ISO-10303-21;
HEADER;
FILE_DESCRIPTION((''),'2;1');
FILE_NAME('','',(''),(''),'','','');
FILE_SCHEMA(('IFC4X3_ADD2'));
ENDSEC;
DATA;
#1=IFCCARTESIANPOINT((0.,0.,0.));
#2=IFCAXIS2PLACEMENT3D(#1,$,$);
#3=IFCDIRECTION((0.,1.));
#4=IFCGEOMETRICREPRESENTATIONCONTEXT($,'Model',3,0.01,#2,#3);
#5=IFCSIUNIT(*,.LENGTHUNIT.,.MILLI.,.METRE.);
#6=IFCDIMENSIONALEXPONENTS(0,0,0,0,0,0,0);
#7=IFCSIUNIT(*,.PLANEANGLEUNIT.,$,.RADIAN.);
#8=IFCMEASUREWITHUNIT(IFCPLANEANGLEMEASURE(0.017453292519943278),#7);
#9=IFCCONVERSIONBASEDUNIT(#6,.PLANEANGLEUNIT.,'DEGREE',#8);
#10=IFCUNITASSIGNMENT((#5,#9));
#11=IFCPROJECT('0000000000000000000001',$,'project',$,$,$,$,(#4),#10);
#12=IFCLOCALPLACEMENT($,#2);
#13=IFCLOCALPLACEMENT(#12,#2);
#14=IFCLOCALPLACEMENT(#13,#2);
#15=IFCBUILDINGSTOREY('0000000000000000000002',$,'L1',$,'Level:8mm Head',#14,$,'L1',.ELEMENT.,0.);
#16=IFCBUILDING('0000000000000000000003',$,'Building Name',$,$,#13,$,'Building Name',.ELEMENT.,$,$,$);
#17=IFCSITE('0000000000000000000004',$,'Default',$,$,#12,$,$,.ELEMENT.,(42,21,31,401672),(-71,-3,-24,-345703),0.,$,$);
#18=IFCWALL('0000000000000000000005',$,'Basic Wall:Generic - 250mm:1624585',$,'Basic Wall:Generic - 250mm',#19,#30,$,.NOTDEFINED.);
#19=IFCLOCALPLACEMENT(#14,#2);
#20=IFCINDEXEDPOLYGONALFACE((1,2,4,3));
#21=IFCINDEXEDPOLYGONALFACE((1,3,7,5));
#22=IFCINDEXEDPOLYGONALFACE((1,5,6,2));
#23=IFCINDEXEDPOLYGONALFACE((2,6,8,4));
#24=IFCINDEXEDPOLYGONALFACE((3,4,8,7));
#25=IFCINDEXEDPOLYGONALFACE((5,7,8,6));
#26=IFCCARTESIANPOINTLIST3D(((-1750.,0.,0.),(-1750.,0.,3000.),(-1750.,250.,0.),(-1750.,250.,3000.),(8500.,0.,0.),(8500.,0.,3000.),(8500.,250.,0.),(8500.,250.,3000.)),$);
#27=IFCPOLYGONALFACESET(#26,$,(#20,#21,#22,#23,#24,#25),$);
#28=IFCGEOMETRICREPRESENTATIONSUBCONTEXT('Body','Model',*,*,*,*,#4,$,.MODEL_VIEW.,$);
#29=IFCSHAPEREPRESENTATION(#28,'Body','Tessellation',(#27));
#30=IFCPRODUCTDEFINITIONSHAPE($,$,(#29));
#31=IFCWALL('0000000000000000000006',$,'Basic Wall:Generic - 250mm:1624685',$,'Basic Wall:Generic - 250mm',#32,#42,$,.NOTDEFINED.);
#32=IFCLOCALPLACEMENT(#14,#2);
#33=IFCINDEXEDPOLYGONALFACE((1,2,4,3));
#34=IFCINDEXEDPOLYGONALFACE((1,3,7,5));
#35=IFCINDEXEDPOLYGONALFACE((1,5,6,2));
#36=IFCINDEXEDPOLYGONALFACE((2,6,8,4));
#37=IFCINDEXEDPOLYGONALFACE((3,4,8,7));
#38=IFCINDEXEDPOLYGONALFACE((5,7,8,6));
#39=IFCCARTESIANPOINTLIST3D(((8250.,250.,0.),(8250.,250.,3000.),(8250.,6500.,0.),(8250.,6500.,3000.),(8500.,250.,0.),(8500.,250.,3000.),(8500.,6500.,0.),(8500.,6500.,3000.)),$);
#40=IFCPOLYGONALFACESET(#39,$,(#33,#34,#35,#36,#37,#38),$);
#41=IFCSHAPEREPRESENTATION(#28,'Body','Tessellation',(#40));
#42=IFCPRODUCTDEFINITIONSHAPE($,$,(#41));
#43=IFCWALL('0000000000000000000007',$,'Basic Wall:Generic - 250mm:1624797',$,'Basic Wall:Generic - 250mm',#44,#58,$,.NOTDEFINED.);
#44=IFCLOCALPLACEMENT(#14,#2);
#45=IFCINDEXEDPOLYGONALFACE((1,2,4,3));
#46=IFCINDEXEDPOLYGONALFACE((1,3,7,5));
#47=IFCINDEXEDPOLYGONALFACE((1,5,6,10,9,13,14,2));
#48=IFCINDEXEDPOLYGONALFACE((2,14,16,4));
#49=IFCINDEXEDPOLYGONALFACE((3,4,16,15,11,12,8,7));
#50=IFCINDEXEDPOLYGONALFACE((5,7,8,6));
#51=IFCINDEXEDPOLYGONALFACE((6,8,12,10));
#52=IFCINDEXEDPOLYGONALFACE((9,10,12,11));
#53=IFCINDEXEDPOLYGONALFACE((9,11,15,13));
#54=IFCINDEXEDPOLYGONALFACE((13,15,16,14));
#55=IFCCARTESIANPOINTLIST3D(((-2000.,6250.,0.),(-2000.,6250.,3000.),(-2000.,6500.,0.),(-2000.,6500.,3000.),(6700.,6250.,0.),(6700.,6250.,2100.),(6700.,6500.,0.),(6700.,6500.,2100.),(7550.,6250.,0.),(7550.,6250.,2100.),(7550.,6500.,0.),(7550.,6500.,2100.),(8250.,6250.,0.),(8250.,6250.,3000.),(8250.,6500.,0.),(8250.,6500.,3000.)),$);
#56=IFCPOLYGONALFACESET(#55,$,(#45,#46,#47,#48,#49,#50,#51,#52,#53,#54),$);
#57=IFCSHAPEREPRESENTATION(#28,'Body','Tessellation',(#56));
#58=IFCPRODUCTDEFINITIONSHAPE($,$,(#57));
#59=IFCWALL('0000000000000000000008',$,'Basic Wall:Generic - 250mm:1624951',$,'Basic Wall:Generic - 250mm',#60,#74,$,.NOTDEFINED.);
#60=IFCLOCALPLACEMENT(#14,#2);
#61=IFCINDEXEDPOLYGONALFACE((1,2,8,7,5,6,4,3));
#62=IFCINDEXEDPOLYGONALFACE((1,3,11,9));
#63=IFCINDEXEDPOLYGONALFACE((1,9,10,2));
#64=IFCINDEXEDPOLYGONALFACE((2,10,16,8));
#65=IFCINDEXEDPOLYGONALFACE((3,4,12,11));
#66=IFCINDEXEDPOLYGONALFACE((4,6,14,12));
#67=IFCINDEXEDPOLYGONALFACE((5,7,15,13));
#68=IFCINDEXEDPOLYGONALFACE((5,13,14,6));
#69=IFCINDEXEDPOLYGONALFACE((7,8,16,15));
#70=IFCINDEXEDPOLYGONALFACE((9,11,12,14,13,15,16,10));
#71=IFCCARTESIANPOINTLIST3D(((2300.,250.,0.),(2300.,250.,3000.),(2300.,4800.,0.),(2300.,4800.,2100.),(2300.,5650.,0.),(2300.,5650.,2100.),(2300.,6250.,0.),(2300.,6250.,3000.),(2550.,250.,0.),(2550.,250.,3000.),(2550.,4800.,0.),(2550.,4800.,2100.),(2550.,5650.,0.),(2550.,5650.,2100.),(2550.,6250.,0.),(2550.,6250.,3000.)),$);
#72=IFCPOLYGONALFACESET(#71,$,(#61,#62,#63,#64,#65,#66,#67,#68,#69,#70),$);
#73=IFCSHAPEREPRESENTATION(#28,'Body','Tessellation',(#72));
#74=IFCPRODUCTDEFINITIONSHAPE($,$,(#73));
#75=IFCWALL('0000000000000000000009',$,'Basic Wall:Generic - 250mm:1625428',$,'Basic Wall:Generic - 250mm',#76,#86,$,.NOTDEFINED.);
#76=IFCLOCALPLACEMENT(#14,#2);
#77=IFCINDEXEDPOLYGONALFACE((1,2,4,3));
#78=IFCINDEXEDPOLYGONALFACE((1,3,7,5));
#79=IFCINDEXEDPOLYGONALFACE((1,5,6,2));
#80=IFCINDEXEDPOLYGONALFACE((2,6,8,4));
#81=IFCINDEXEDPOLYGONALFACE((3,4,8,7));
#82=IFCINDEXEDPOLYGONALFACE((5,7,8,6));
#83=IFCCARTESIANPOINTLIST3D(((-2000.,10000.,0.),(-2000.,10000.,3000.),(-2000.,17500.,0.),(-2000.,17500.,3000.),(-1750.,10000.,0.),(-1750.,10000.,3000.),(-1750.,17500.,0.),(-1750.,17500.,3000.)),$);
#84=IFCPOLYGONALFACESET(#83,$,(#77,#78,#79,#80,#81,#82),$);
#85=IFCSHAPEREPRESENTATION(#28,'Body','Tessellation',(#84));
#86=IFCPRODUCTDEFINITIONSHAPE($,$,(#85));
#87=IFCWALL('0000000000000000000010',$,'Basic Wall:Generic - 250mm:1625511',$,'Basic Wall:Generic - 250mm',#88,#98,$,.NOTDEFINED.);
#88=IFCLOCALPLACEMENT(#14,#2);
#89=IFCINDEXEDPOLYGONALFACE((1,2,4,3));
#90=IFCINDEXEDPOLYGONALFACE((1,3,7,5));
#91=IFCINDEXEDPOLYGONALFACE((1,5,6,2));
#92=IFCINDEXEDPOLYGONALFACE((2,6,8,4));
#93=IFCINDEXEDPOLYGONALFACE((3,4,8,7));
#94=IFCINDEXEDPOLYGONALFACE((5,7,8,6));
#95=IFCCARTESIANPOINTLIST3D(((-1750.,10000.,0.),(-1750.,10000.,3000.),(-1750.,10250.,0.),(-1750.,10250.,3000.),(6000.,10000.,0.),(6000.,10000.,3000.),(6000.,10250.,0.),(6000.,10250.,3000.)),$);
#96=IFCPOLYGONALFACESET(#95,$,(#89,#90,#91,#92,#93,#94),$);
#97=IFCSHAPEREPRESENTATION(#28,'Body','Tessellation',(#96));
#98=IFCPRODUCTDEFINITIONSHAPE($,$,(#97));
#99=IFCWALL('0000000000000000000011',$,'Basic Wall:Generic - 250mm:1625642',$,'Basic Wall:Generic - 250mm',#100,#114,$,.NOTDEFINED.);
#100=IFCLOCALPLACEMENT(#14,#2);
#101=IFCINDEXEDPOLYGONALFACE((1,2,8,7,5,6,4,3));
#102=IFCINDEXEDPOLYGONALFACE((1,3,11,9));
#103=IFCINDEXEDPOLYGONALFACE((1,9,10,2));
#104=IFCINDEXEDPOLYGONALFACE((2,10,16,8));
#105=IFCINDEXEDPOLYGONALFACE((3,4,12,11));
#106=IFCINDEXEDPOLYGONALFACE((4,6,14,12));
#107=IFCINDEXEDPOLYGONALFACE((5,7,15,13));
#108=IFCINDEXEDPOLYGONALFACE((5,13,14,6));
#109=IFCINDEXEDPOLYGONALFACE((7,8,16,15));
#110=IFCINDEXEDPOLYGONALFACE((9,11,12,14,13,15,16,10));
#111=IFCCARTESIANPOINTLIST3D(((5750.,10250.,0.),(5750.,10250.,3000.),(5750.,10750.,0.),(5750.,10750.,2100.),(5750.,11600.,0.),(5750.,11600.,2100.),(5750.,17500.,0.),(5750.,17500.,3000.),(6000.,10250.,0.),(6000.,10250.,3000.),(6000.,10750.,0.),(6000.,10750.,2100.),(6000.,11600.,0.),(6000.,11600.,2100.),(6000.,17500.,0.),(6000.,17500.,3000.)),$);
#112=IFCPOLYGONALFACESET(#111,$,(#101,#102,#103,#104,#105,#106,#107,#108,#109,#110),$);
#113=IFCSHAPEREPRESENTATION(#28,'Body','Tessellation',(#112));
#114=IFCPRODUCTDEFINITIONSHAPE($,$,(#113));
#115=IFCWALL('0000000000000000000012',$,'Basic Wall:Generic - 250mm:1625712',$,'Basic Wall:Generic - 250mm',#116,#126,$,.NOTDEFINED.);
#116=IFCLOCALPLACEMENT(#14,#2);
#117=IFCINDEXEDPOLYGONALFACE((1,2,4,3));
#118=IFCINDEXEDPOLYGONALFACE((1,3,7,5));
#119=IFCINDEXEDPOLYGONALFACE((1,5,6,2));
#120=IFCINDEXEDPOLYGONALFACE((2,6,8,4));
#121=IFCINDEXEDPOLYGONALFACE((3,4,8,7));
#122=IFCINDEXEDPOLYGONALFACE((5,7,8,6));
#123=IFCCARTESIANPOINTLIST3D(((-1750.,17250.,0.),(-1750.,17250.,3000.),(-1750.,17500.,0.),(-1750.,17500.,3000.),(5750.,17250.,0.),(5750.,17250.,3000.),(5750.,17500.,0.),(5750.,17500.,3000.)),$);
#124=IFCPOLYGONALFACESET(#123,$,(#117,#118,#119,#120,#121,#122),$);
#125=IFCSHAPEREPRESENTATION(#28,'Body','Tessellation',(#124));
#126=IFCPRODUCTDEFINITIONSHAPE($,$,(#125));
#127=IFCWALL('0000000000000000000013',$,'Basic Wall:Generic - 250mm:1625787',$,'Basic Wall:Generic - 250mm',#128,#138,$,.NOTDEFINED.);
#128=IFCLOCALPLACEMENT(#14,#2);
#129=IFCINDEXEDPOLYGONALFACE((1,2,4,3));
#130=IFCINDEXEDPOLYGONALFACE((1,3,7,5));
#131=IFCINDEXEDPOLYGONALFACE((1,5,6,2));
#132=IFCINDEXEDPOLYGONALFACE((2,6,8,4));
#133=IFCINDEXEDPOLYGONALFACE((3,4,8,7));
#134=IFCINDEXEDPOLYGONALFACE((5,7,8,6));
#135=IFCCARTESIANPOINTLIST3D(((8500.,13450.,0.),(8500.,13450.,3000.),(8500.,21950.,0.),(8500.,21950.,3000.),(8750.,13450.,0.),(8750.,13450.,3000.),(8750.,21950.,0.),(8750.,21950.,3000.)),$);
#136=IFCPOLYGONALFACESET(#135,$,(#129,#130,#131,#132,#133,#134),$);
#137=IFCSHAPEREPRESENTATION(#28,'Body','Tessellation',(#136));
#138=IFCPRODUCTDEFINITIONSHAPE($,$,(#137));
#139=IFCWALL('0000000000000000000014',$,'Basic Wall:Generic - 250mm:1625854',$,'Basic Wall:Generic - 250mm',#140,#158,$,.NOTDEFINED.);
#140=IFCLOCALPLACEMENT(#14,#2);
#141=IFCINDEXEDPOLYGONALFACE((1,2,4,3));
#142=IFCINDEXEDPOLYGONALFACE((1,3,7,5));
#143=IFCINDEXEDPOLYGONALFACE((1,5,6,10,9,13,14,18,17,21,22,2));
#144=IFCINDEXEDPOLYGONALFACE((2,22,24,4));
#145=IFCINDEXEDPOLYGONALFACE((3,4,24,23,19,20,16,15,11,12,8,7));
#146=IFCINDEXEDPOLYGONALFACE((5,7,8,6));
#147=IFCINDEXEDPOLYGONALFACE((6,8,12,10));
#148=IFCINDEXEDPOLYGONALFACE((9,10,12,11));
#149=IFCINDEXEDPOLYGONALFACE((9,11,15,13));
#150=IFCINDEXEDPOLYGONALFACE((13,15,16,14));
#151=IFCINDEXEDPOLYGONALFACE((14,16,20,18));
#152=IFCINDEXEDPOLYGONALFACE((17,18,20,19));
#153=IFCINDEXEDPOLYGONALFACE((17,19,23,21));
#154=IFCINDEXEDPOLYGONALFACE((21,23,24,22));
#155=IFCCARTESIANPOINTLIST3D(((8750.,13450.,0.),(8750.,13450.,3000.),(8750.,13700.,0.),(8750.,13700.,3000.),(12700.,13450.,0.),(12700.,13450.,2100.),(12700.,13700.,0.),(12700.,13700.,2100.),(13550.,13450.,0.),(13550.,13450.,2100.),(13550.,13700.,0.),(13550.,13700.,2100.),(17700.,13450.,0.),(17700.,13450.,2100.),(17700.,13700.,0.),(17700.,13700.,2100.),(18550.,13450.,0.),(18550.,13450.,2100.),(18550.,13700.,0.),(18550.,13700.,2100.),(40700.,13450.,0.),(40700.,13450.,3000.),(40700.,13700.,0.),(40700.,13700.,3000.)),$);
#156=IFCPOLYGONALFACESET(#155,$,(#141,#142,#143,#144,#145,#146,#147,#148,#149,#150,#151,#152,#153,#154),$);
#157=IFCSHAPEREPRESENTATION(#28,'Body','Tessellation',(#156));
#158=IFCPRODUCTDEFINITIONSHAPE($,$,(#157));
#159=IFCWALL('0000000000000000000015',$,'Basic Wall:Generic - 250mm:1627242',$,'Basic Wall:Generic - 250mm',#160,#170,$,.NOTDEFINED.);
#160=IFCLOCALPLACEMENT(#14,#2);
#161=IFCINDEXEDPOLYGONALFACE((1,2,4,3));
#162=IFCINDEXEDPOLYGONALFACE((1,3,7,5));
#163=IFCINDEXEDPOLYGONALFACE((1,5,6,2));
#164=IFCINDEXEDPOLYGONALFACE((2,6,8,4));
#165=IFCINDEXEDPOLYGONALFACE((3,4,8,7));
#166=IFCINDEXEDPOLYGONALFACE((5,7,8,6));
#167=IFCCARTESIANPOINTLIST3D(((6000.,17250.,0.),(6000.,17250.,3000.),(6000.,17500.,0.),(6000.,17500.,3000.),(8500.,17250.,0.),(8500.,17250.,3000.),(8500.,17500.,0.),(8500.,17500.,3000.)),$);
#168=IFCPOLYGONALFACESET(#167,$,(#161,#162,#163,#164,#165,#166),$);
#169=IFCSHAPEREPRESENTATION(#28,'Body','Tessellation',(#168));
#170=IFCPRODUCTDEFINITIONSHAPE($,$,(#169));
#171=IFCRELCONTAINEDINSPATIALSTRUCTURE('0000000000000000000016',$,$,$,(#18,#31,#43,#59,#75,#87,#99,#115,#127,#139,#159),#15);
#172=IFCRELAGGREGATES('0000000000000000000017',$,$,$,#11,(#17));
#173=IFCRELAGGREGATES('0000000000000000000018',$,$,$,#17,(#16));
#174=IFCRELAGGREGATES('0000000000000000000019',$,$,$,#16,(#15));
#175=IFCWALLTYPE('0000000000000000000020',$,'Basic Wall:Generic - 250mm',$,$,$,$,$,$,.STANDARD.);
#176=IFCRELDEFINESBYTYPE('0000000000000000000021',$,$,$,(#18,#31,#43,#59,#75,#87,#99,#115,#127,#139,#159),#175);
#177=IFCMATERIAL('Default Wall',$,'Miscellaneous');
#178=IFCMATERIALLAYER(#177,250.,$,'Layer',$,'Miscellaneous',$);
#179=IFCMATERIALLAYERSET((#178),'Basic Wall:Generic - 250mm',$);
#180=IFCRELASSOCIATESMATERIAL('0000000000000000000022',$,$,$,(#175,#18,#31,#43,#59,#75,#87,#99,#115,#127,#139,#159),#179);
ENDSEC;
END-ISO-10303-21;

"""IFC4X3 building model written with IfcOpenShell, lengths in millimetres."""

from ifc_helpers import new_model, entity, si_unit, converted_unit, direction, frame, frame_2d, origin, place, context, subcontext, project, spatial, rectangle, extrude, material, layer, layer_set, type_object, element, save


model = new_model("IFC4X3")

# Units and contexts
model_context = context("Model", 3, precision=0.01, world=origin(), true_north=direction((0.0, 1.0)))
body_context = subcontext(model_context, "Body", "Model", "MODEL_VIEW")
ifc_project = project(units=[si_unit("LENGTHUNIT", "METRE", prefix="MILLI"), converted_unit("PLANEANGLEUNIT", "DEGREE", entity("IfcPlaneAngleMeasure", 0.017453292519943278), si_unit("PLANEANGLEUNIT", "RADIAN"), dimensions=[0, 0, 0, 0, 0, 0, 0])], contexts=[model_context])

# Site, building, storey
site_placement = place(None, origin())
site = spatial("IfcSite", under=ifc_project, at=site_placement, Name="Default", CompositionType="ELEMENT", RefLatitude=(42, 21, 31, 401672), RefLongitude=(-71, -3, -24, -345703), RefElevation=0.0)
building_placement = place(site_placement, origin())
building = spatial("IfcBuilding", under=site, at=building_placement, Name="Building Name", LongName="Building Name", CompositionType="ELEMENT")
storey_placement = place(building_placement, origin())
storey = spatial("IfcBuildingStorey", under=building, at=storey_placement, Name="L1", ObjectType="Level:8mm Head", LongName="L1", CompositionType="ELEMENT", Elevation=0.0)

# Walls
ifc_material = material(Name="Default Wall", Category="Miscellaneous")
ifc_layer = layer(ifc_material, 250.0, Name="Layer", Category="Miscellaneous")
ifc_layer_set = layer_set([ifc_layer], Name="Basic Wall:Generic - 250mm")
wall_type = type_object("IfcWallType", Name="Basic Wall:Generic - 250mm", PredefinedType="STANDARD", material=ifc_layer_set)
wall_1_placement = place(storey_placement, frame((-1750.0, 125.0, 0.0)))
element("IfcWall", 1, at=wall_1_placement, inside=storey, type_object=wall_type, material=ifc_layer_set, Name="Basic Wall:Generic - 250mm:1624585", ObjectType="Basic Wall:Generic - 250mm", PredefinedType="NOTDEFINED", context=body_context, shape_type="SweptSolid", body=[
    extrude(rectangle(XDim=10250.0, YDim=250.0, at=frame_2d((5125.0, 0.0), x_axis=(-1.0, 0.0))), origin(), (0.0, 0.0, 1.0), 3000.0),
])
wall_2_placement = place(storey_placement, frame((8375.0, 250.0, 0.0), z_axis=(0.0, 0.0, 1.0), x_axis=(0.0, 1.0, 0.0)))
element("IfcWall", 2, at=wall_2_placement, inside=storey, type_object=wall_type, material=ifc_layer_set, Name="Basic Wall:Generic - 250mm:1624685", ObjectType="Basic Wall:Generic - 250mm", PredefinedType="NOTDEFINED", context=body_context, shape_type="SweptSolid", body=[
    extrude(rectangle(XDim=6250.0, YDim=250.0, at=frame_2d((3125.0, 0.0), x_axis=(-1.0, 0.0))), origin(), (0.0, 0.0, 1.0), 3000.0),
])

# Walls, openings
wall_3_placement = place(storey_placement, frame((8250.0, 6375.0, 0.0), z_axis=(0.0, 0.0, 1.0), x_axis=(-1.0, 0.0, 0.0)))
wall_3 = element("IfcWall", 3, at=wall_3_placement, inside=storey, type_object=wall_type, material=ifc_layer_set, Name="Basic Wall:Generic - 250mm:1624797", ObjectType="Basic Wall:Generic - 250mm", PredefinedType="NOTDEFINED", context=body_context, shape_type="SweptSolid", body=[
    extrude(rectangle(XDim=10250.0, YDim=250.0, at=frame_2d((5125.0, 0.0), x_axis=(1.0, 0.0))), origin(), (0.0, 0.0, 1.0), 3000.0),
])
opening_1_placement = place(wall_3_placement, frame((700.0, -125.0, 0.0)))
element("IfcOpeningElement", 4, at=opening_1_placement, cuts=wall_3, PredefinedType="OPENING", context=body_context, shape_type="SweptSolid", body=[
    extrude(rectangle(XDim=2100.0, YDim=850.0, at=frame_2d((1050.0, 425.0), x_axis=(1.0, 0.0))), frame((0.0, 0.0, 0.0), z_axis=(0.0, 1.0, 0.0), x_axis=(0.0, 0.0, 1.0)), (0.0, 0.0, 1.0), 250.0),
])
wall_4_placement = place(storey_placement, frame((2425.0, 6250.0, 0.0), z_axis=(0.0, 0.0, 1.0), x_axis=(0.0, -1.0, 0.0)))
wall_4 = element("IfcWall", 5, at=wall_4_placement, inside=storey, type_object=wall_type, material=ifc_layer_set, Name="Basic Wall:Generic - 250mm:1624951", ObjectType="Basic Wall:Generic - 250mm", PredefinedType="NOTDEFINED", context=body_context, shape_type="SweptSolid", body=[
    extrude(rectangle(XDim=6000.0, YDim=250.0, at=frame_2d((3000.0, 0.0), x_axis=(1.0, 0.0))), origin(), (0.0, 0.0, 1.0), 3000.0),
])
opening_2_placement = place(wall_4_placement, frame((1450.0, 125.0, 0.0)))
element("IfcOpeningElement", 6, at=opening_2_placement, cuts=wall_4, PredefinedType="OPENING", context=body_context, shape_type="SweptSolid", body=[
    extrude(rectangle(XDim=2100.0, YDim=850.0, at=frame_2d((1050.0, 425.0), x_axis=(1.0, 0.0))), frame((0.0, 0.0, 0.0), z_axis=(0.0, -1.0, 0.0), x_axis=(0.0, 0.0, 1.0)), (0.0, 0.0, 1.0), 250.0),
])

# Walls
wall_5_placement = place(storey_placement, frame((-1875.0, 17500.0, 0.0), z_axis=(0.0, 0.0, 1.0), x_axis=(0.0, -1.0, 0.0)))
element("IfcWall", 7, at=wall_5_placement, inside=storey, type_object=wall_type, material=ifc_layer_set, Name="Basic Wall:Generic - 250mm:1625428", ObjectType="Basic Wall:Generic - 250mm", PredefinedType="NOTDEFINED", context=body_context, shape_type="SweptSolid", body=[
    extrude(rectangle(XDim=7500.0, YDim=250.0, at=frame_2d((3750.0, 0.0), x_axis=(-1.0, 0.0))), origin(), (0.0, 0.0, 1.0), 3000.0),
])
wall_6_placement = place(storey_placement, frame((-1750.0, 10125.0, 0.0)))
element("IfcWall", 8, at=wall_6_placement, inside=storey, type_object=wall_type, material=ifc_layer_set, Name="Basic Wall:Generic - 250mm:1625511", ObjectType="Basic Wall:Generic - 250mm", PredefinedType="NOTDEFINED", context=body_context, shape_type="SweptSolid", body=[
    extrude(rectangle(XDim=7750.0, YDim=250.0, at=frame_2d((3875.0, 0.0), x_axis=(-1.0, 0.0))), origin(), (0.0, 0.0, 1.0), 3000.0),
])

# Wall, opening
wall_7_placement = place(storey_placement, frame((5875.0, 10250.0, 0.0), z_axis=(0.0, 0.0, 1.0), x_axis=(0.0, 1.0, 0.0)))
wall_7 = element("IfcWall", 9, at=wall_7_placement, inside=storey, type_object=wall_type, material=ifc_layer_set, Name="Basic Wall:Generic - 250mm:1625642", ObjectType="Basic Wall:Generic - 250mm", PredefinedType="NOTDEFINED", context=body_context, shape_type="SweptSolid", body=[
    extrude(rectangle(XDim=7250.0, YDim=250.0, at=frame_2d((3625.0, 0.0), x_axis=(1.0, 0.0))), origin(), (0.0, 0.0, 1.0), 3000.0),
])
opening_3_placement = place(wall_7_placement, frame((500.0, -125.0, 0.0)))
element("IfcOpeningElement", 10, at=opening_3_placement, cuts=wall_7, PredefinedType="OPENING", context=body_context, shape_type="SweptSolid", body=[
    extrude(rectangle(XDim=2100.0, YDim=850.0, at=frame_2d((1050.0, 425.0), x_axis=(1.0, 0.0))), frame((0.0, 0.0, 0.0), z_axis=(0.0, 1.0, 0.0), x_axis=(0.0, 0.0, 1.0)), (0.0, 0.0, 1.0), 250.0),
])

# Walls
wall_8_placement = place(storey_placement, frame((5750.0, 17375.0, 0.0), z_axis=(0.0, 0.0, 1.0), x_axis=(-1.0, 0.0, 0.0)))
element("IfcWall", 11, at=wall_8_placement, inside=storey, type_object=wall_type, material=ifc_layer_set, Name="Basic Wall:Generic - 250mm:1625712", ObjectType="Basic Wall:Generic - 250mm", PredefinedType="NOTDEFINED", context=body_context, shape_type="SweptSolid", body=[
    extrude(rectangle(XDim=7500.0, YDim=250.0, at=frame_2d((3750.0, 0.0), x_axis=(-1.0, 0.0))), origin(), (0.0, 0.0, 1.0), 3000.0),
])
wall_9_placement = place(storey_placement, frame((8625.0, 21950.0, 0.0), z_axis=(0.0, 0.0, 1.0), x_axis=(0.0, -1.0, 0.0)))
element("IfcWall", 12, at=wall_9_placement, inside=storey, type_object=wall_type, material=ifc_layer_set, Name="Basic Wall:Generic - 250mm:1625787", ObjectType="Basic Wall:Generic - 250mm", PredefinedType="NOTDEFINED", context=body_context, shape_type="SweptSolid", body=[
    extrude(rectangle(XDim=8500.0, YDim=250.0, at=frame_2d((4250.0, 0.0), x_axis=(-1.0, 0.0))), origin(), (0.0, 0.0, 1.0), 3000.0),
])

# Wall, openings
wall_10_placement = place(storey_placement, frame((8750.0, 13575.0, 0.0)))
wall_10 = element("IfcWall", 13, at=wall_10_placement, inside=storey, type_object=wall_type, material=ifc_layer_set, Name="Basic Wall:Generic - 250mm:1625854", ObjectType="Basic Wall:Generic - 250mm", PredefinedType="NOTDEFINED", context=body_context, shape_type="SweptSolid", body=[
    extrude(rectangle(XDim=31950.0, YDim=250.0, at=frame_2d((15975.0, 0.0), x_axis=(1.0, 0.0))), origin(), (0.0, 0.0, 1.0), 3000.0),
])
opening_4_placement = place(wall_10_placement, frame((3950.0, -125.0, 0.0)))
element("IfcOpeningElement", 14, at=opening_4_placement, cuts=wall_10, PredefinedType="OPENING", context=body_context, shape_type="SweptSolid", body=[
    extrude(rectangle(XDim=2100.0, YDim=850.0, at=frame_2d((1050.0, 425.0), x_axis=(1.0, 0.0))), frame((0.0, 0.0, 0.0), z_axis=(0.0, 1.0, 0.0), x_axis=(0.0, 0.0, 1.0)), (0.0, 0.0, 1.0), 250.0),
])
opening_5_placement = place(wall_10_placement, frame((8950.0, -125.0, 0.0)))
element("IfcOpeningElement", 15, at=opening_5_placement, cuts=wall_10, PredefinedType="OPENING", context=body_context, shape_type="SweptSolid", body=[
    extrude(rectangle(XDim=2100.0, YDim=850.0, at=frame_2d((1050.0, 425.0), x_axis=(1.0, 0.0))), frame((0.0, 0.0, 0.0), z_axis=(0.0, 1.0, 0.0), x_axis=(0.0, 0.0, 1.0)), (0.0, 0.0, 1.0), 250.0),
])

# Wall
wall_11_placement = place(storey_placement, frame((6000.0, 17375.0, 0.0)))
element("IfcWall", 16, at=wall_11_placement, inside=storey, type_object=wall_type, material=ifc_layer_set, Name="Basic Wall:Generic - 250mm:1627242", ObjectType="Basic Wall:Generic - 250mm", PredefinedType="NOTDEFINED", context=body_context, shape_type="SweptSolid", body=[
    extrude(rectangle(XDim=2500.0, YDim=250.0, at=frame_2d((1250.0, 0.0), x_axis=(-1.0, 0.0))), origin(), (0.0, 0.0, 1.0), 3000.0),
])

save(model, "model.ifc")
